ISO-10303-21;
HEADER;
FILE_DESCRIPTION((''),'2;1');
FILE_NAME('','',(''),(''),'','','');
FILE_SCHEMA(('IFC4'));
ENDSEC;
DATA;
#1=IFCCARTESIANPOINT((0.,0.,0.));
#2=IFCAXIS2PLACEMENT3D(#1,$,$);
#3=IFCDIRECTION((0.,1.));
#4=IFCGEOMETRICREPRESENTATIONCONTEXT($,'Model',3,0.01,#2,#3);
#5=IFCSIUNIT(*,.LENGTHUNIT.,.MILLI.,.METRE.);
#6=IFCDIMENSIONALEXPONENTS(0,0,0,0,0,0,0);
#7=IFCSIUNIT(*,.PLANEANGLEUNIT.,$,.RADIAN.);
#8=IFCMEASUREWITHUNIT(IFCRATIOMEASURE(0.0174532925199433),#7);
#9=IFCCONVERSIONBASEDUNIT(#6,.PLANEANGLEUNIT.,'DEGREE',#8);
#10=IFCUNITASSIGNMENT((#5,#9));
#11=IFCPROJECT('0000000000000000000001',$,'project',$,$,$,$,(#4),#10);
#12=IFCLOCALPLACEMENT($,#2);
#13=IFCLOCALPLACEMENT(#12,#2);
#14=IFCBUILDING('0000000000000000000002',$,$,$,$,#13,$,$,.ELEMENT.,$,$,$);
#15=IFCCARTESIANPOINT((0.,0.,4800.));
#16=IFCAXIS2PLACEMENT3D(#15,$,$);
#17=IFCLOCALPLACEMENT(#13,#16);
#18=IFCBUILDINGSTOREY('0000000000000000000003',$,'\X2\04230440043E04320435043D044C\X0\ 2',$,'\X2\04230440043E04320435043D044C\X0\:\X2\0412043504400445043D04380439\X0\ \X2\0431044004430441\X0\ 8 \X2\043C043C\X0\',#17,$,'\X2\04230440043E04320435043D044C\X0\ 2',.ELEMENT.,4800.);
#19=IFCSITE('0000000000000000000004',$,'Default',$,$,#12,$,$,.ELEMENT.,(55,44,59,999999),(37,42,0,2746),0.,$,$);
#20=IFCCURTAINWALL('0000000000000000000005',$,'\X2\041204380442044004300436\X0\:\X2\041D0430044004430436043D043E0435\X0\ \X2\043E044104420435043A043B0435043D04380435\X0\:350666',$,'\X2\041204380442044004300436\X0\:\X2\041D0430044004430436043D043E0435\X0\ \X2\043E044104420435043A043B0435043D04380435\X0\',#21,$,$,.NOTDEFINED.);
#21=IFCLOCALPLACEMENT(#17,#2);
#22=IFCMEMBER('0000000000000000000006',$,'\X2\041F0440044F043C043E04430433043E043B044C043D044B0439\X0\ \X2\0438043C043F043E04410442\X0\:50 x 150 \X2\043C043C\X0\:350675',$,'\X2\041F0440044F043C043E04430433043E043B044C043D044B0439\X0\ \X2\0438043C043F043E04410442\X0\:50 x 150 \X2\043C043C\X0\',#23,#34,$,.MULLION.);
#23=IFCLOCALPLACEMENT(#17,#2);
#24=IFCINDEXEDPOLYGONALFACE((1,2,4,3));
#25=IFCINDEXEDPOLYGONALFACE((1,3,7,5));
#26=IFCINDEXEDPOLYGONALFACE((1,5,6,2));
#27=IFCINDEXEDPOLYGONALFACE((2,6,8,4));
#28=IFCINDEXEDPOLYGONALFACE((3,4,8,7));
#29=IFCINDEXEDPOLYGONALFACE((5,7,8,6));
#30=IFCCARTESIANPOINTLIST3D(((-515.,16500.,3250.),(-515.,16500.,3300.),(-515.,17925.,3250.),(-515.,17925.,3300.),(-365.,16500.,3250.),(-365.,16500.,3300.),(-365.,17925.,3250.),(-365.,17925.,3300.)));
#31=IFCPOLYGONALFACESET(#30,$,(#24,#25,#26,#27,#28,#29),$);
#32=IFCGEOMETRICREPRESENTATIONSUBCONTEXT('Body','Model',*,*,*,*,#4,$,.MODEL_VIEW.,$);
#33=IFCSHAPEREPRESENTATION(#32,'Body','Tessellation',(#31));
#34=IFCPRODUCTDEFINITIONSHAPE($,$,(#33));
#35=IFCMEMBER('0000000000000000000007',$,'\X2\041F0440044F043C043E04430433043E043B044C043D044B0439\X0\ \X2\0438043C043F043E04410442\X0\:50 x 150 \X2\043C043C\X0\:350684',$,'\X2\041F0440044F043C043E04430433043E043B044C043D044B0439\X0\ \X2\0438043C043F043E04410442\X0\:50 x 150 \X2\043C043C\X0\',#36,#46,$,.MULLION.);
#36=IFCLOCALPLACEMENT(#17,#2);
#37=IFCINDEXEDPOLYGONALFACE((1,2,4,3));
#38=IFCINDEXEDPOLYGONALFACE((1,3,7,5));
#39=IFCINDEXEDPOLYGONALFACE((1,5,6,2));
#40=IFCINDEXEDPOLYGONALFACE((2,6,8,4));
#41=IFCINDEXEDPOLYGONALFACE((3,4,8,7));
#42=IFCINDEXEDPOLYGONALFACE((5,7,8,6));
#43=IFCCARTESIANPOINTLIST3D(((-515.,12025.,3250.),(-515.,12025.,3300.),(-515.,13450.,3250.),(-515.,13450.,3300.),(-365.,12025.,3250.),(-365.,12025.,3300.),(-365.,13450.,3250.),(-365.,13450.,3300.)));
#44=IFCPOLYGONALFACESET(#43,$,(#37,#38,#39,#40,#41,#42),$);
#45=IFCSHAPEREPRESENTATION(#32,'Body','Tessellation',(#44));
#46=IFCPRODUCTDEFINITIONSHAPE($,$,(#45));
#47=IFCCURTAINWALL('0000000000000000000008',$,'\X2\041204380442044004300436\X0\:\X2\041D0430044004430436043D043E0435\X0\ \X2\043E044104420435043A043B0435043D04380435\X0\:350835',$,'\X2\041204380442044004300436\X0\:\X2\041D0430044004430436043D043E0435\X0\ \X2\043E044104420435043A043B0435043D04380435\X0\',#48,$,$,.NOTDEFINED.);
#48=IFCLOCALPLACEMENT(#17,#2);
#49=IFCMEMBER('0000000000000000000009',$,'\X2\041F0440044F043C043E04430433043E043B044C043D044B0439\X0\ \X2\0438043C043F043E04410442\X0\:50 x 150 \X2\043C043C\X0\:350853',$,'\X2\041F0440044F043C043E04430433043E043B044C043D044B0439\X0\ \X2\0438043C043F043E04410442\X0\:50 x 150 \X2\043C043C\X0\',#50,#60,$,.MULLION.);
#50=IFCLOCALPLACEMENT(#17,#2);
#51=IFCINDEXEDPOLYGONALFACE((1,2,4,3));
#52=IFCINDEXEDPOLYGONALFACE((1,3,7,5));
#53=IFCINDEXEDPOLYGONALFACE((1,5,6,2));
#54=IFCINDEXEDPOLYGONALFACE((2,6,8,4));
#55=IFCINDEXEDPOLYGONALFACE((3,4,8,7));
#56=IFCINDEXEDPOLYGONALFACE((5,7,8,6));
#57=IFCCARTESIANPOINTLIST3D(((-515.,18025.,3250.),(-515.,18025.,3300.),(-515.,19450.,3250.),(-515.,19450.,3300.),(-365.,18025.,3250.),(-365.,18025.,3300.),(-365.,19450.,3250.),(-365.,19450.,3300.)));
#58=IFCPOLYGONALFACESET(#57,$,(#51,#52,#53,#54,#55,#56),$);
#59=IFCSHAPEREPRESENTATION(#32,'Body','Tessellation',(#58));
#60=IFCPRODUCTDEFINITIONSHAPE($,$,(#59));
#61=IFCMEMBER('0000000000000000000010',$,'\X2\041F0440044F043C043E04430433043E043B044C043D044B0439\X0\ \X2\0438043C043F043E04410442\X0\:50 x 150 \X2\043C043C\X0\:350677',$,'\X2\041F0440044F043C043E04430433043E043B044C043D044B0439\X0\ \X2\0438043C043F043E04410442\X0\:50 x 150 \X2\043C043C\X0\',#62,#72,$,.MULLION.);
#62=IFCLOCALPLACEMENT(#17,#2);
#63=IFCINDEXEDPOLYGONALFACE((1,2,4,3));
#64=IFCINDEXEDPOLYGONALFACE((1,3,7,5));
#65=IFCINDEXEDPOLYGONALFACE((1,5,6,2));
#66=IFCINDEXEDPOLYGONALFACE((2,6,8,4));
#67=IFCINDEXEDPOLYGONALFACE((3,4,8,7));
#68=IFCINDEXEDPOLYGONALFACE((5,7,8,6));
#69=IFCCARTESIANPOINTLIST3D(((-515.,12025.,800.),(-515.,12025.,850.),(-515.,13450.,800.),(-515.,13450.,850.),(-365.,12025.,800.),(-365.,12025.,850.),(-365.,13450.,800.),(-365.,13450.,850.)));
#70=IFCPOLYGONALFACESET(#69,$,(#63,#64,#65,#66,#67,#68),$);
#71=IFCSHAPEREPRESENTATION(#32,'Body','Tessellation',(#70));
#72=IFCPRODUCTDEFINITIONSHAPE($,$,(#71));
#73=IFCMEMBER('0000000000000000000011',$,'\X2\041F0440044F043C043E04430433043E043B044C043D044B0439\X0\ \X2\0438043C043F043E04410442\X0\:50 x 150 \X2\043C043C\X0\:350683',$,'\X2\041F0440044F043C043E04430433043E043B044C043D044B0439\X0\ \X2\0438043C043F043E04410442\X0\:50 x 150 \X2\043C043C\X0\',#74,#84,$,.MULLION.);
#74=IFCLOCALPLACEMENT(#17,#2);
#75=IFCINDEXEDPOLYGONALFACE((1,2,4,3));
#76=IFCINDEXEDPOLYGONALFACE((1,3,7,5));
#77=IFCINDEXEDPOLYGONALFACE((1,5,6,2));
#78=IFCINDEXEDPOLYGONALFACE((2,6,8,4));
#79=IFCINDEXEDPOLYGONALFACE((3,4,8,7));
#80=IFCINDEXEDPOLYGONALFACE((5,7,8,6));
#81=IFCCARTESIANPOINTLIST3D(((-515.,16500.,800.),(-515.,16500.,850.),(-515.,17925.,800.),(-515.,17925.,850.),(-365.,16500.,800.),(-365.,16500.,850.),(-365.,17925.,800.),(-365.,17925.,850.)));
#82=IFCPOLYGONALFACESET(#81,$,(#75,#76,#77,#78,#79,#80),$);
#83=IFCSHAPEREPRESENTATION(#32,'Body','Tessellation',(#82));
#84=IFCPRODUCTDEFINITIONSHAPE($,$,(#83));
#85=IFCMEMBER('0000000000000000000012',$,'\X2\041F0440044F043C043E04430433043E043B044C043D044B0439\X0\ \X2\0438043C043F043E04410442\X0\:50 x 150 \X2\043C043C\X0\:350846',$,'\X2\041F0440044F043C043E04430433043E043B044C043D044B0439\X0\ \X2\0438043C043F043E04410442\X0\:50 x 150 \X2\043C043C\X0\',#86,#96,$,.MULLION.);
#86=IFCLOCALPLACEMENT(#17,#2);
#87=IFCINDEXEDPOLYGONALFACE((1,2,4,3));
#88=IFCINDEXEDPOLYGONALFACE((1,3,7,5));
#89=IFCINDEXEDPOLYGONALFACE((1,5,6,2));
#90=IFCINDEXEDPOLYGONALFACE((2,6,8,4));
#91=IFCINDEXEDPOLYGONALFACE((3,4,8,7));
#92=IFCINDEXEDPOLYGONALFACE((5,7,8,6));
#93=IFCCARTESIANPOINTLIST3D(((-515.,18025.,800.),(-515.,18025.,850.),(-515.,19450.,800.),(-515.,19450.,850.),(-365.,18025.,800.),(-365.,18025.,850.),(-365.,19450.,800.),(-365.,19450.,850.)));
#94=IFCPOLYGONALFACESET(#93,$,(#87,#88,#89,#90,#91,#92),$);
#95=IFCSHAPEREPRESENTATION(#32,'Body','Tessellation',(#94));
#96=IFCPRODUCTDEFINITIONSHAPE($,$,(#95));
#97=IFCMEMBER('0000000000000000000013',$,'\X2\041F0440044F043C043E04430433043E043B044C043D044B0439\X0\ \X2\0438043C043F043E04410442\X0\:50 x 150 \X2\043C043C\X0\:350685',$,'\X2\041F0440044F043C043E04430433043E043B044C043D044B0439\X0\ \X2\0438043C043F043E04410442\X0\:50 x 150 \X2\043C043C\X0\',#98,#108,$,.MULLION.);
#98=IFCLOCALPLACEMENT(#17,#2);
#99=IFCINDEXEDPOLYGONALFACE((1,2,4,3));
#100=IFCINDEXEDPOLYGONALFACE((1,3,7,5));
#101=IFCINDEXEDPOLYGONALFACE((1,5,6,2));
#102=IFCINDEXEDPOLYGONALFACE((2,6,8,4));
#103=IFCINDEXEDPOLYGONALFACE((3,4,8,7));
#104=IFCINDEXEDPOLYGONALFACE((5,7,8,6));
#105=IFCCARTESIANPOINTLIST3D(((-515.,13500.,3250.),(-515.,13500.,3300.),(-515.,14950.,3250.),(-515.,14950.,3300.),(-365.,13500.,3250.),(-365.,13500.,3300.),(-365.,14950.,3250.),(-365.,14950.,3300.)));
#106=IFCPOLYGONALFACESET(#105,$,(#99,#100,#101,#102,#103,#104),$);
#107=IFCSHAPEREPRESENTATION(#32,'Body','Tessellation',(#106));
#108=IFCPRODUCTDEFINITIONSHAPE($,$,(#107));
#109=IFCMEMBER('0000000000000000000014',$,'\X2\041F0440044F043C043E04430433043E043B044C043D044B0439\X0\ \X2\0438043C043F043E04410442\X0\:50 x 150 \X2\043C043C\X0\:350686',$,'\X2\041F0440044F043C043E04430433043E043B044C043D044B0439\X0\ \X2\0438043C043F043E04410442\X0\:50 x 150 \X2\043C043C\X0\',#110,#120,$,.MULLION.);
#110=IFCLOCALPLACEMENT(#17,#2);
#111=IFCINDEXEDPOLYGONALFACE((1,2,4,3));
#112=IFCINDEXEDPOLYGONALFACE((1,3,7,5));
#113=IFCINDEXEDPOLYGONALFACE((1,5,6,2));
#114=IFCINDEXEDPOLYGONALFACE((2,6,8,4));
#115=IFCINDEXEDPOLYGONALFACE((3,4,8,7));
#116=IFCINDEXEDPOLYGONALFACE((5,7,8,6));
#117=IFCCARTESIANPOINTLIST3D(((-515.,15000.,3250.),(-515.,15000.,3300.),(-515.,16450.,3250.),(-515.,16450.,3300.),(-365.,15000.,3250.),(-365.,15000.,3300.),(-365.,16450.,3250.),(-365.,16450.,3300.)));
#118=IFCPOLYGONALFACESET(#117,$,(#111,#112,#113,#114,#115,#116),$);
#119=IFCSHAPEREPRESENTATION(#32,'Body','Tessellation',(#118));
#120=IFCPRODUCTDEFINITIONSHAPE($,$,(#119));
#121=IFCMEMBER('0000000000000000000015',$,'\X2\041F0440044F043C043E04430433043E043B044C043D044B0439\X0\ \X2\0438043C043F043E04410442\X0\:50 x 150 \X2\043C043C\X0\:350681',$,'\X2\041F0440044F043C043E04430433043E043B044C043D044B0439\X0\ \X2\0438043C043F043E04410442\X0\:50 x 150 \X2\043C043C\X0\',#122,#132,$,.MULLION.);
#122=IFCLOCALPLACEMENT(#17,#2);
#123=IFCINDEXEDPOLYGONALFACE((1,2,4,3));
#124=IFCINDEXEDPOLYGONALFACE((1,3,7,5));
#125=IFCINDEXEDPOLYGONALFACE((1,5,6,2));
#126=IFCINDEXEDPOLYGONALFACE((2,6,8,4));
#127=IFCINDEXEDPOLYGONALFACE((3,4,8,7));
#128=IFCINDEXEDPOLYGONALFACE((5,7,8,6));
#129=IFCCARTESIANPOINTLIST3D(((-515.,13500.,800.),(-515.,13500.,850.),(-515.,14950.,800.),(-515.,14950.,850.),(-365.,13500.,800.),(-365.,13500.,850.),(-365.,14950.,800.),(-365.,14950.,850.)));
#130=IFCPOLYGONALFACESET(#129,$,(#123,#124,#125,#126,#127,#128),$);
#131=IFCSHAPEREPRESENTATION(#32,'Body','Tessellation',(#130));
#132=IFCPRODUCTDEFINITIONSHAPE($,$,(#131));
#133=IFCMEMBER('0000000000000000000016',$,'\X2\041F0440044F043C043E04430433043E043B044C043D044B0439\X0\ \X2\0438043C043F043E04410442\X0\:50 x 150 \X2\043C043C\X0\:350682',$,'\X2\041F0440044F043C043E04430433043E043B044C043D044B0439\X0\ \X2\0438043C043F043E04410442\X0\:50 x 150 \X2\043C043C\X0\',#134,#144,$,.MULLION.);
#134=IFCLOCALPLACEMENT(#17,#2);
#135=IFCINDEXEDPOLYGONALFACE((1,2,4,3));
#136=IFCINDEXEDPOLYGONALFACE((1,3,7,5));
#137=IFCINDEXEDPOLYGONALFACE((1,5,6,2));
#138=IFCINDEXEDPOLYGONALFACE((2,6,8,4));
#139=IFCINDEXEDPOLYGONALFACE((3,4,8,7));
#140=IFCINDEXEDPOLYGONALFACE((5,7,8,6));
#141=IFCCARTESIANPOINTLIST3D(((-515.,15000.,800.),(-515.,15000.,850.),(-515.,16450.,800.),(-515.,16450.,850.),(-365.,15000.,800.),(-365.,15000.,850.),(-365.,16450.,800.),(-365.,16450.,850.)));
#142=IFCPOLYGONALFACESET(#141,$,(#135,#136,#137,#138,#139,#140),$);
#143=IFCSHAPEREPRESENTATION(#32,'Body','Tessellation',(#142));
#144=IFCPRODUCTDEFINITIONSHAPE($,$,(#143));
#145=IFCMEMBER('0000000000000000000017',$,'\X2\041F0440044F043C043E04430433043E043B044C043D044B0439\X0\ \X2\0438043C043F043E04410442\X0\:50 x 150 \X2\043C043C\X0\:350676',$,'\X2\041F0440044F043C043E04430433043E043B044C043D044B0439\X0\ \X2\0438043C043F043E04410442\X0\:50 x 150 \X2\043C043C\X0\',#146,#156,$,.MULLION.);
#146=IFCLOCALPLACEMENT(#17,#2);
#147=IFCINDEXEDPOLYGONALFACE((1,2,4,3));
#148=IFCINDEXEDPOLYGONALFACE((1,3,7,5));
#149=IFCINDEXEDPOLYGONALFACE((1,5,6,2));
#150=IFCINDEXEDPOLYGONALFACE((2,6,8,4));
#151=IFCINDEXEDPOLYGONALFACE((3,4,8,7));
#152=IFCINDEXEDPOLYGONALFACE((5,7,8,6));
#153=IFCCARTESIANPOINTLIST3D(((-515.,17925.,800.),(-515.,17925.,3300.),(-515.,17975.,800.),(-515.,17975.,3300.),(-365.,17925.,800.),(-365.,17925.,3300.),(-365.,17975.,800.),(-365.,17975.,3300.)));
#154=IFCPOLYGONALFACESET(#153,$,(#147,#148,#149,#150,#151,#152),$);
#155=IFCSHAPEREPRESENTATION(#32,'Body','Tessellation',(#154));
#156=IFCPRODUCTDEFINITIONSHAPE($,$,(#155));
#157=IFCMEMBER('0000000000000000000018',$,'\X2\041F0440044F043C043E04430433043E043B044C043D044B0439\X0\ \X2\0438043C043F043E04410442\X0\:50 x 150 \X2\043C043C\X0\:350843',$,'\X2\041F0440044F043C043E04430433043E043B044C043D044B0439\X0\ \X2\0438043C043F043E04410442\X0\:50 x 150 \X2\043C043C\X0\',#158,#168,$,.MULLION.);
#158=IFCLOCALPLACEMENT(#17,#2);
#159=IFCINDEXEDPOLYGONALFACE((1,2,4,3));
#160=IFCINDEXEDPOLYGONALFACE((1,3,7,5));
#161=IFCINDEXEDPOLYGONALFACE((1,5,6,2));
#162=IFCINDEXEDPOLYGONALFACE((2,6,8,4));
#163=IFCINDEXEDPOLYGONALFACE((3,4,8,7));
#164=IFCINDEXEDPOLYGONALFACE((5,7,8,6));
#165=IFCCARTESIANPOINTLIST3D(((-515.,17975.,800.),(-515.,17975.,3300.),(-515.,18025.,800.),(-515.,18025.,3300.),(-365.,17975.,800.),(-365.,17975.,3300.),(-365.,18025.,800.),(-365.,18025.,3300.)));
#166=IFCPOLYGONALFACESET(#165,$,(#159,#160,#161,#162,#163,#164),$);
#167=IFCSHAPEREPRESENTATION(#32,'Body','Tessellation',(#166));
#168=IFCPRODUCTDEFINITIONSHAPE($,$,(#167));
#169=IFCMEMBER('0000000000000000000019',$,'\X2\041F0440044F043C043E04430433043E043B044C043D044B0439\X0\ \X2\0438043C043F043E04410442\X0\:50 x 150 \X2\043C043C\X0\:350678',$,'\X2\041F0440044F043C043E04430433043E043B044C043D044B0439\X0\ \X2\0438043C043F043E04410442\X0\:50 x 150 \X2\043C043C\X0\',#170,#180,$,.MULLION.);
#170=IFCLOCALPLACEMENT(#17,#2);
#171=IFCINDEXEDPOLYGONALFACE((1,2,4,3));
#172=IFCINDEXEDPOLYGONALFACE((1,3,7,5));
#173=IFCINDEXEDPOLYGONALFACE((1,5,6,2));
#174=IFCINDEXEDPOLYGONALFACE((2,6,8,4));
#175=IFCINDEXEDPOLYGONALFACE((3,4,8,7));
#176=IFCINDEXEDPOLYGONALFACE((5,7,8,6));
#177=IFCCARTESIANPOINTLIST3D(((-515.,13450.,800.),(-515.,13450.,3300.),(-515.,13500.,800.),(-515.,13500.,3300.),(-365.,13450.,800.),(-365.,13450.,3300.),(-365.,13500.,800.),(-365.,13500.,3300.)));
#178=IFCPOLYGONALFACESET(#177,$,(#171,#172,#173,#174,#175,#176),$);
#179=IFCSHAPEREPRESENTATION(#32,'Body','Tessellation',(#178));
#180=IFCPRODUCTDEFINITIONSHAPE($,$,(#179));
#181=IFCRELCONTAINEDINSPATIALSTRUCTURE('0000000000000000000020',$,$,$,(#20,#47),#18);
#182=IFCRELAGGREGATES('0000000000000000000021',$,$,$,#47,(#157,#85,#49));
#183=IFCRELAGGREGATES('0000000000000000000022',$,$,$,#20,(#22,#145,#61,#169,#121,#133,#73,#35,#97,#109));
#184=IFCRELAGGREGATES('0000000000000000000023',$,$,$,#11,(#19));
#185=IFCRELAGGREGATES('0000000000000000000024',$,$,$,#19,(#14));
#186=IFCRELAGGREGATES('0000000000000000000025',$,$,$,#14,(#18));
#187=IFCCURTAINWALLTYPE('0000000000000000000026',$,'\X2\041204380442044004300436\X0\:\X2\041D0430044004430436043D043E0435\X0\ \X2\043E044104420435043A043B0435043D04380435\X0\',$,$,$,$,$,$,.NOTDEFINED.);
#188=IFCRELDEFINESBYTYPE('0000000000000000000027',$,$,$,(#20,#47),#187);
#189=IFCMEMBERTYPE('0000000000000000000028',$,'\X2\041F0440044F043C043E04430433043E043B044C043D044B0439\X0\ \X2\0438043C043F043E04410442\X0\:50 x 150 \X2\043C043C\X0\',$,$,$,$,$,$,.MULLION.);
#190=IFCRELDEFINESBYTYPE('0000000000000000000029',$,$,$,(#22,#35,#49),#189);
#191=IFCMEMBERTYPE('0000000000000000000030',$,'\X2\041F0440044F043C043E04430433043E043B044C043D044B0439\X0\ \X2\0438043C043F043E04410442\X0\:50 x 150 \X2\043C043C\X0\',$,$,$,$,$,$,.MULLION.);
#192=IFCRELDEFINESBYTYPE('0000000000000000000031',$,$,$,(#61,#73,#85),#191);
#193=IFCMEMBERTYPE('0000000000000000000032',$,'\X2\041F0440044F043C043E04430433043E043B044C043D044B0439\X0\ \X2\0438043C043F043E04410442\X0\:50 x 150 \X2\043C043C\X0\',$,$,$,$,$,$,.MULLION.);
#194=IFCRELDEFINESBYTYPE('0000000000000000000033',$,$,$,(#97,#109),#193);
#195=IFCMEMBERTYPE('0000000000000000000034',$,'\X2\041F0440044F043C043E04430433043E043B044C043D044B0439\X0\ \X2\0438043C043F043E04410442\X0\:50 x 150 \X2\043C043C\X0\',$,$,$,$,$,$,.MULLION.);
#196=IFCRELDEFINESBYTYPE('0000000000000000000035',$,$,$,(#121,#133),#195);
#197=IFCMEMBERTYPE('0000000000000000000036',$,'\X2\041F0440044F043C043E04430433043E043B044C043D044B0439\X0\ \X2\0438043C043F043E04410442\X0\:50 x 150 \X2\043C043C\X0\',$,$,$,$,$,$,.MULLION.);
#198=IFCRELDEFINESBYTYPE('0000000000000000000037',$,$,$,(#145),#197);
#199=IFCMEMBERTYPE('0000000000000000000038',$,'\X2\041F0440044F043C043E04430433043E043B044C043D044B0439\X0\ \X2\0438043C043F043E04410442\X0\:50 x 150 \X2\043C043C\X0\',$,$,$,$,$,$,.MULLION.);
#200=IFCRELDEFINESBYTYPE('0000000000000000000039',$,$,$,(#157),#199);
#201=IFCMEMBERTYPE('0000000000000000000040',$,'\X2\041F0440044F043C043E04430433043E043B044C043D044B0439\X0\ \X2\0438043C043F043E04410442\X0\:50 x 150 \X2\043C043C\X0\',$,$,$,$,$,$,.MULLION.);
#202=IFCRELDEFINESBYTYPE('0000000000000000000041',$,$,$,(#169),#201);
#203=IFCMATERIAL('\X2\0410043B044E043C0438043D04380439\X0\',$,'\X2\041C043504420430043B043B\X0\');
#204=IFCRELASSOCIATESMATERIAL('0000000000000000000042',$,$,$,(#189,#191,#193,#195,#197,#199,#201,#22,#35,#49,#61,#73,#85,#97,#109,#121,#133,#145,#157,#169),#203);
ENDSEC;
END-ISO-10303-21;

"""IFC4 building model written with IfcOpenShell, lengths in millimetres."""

from ifc_helpers import new_model, entity, si_unit, converted_unit, direction, frame, origin, origin_2d_with_axis, place, context, subcontext, project, spatial, rectangle, extrude, source, transform, mapped, material, material_profile, profile_set, profile_usage, type_object, type_shapes, element, aggregate, save


model = new_model("IFC4")

# Units and contexts
model_context = context("Model", 3, precision=0.01, world=origin(), true_north=direction((0.0, 1.0)))
body_context = subcontext(model_context, "Body", "Model", "MODEL_VIEW")
ifc_project = project(units=[si_unit("LENGTHUNIT", "METRE", prefix="MILLI"), converted_unit("PLANEANGLEUNIT", "DEGREE", entity("IfcRatioMeasure", 0.0174532925199433), si_unit("PLANEANGLEUNIT", "RADIAN"), dimensions=[0, 0, 0, 0, 0, 0, 0])], contexts=[model_context])

# Site, building, storey
site_placement = place(None, origin())
site = spatial("IfcSite", under=ifc_project, at=site_placement, Name="Default", CompositionType="ELEMENT", RefLatitude=(55, 44, 59, 999999), RefLongitude=(37, 42, 0, 2746), RefElevation=0.0)
building_placement = place(site_placement, origin())
building = spatial("IfcBuilding", under=site, at=building_placement, CompositionType="ELEMENT")
storey_placement = place(building_placement, frame((0.0, 0.0, 4800.0)))
storey = spatial("IfcBuildingStorey", under=building, at=storey_placement, Name="Уровень 2", ObjectType="Уровень:Верхний брус 8 мм", LongName="Уровень 2", CompositionType="ELEMENT", Elevation=4800.0)

# Curtain wall, members
curtain_wall_type = type_object("IfcCurtainWallType", Name="Витраж:Наружное остекление", PredefinedType="NOTDEFINED")
curtain_wall_1_placement = place(storey_placement, frame((0.0, 0.0, -4800.0)))
curtain_wall_1 = element("IfcCurtainWall", 1, at=curtain_wall_1_placement, inside=storey, type_object=curtain_wall_type, Name="Витраж:Наружное остекление:350666", ObjectType="Витраж:Наружное остекление", PredefinedType="NOTDEFINED")
ifc_material_1 = material(Name="Алюминий", Category="Металл")
ifc_material_profile = material_profile(ifc_material_1, rectangle(XDim=150.0, YDim=50.0, at=origin_2d_with_axis()), Name="50 x 150 мм")
ifc_profile_set = profile_set([ifc_material_profile], Name="50 x 150 мм")
ifc_profile_usage_1 = profile_usage(ifc_profile_set)
member_type_1 = type_object("IfcMemberType", Name="Прямоугольный импост:50 x 150 мм", PredefinedType="MULLION", material=ifc_profile_set)
shared_shape_1 = source(origin(), body_context, "Body", "SweptSolid", [
    extrude(rectangle(XDim=150.0, YDim=50.0, at=origin_2d_with_axis()), frame((-25.0, 0.0, -1425.0), z_axis=(0.0, 0.0, 1.0), x_axis=(0.0, -1.0, 0.0)), (0.0, 0.0, 1.0), 1425.0),
])
type_shapes(member_type_1, [shared_shape_1])
member_1_placement = place(storey_placement, frame((-440.0, 17925.0, 3300.0), z_axis=(0.0, 1.0, 0.0), x_axis=(0.0, 0.0, 1.0)))
member_1 = element("IfcMember", 2, at=member_1_placement, type_object=member_type_1, material=ifc_profile_usage_1, Name="Прямоугольный импост:50 x 150 мм:350675", ObjectType="Прямоугольный импост:50 x 150 мм", PredefinedType="MULLION", context=body_context, shape_type="MappedRepresentation", body=[
    mapped(shared_shape_1, transform((0.0, 0.0, 0.0), scale=1.0)),
])
ifc_profile_usage_2 = profile_usage(ifc_profile_set)
member_2_placement = place(storey_placement, frame((-440.0, 13450.0, 3300.0), z_axis=(0.0, 1.0, 0.0), x_axis=(0.0, 0.0, 1.0)))
member_2 = element("IfcMember", 3, at=member_2_placement, type_object=member_type_1, material=ifc_profile_usage_2, Name="Прямоугольный импост:50 x 150 мм:350684", ObjectType="Прямоугольный импост:50 x 150 мм", PredefinedType="MULLION", context=body_context, shape_type="MappedRepresentation", body=[
    mapped(shared_shape_1, transform((0.0, 0.0, 0.0), scale=1.0)),
])

# Curtain wall, member
curtain_wall_2_placement = place(storey_placement, frame((0.0, 0.0, -4800.0)))
curtain_wall_2 = element("IfcCurtainWall", 4, at=curtain_wall_2_placement, inside=storey, type_object=curtain_wall_type, Name="Витраж:Наружное остекление:350835", ObjectType="Витраж:Наружное остекление", PredefinedType="NOTDEFINED")
ifc_profile_usage_3 = profile_usage(ifc_profile_set)
member_3_placement = place(storey_placement, frame((-440.0, 19450.0, 3300.0), z_axis=(0.0, 1.0, 0.0), x_axis=(0.0, 0.0, 1.0)))
member_3 = element("IfcMember", 5, at=member_3_placement, type_object=member_type_1, material=ifc_profile_usage_3, Name="Прямоугольный импост:50 x 150 мм:350853", ObjectType="Прямоугольный импост:50 x 150 мм", PredefinedType="MULLION", context=body_context, shape_type="MappedRepresentation", body=[
    mapped(shared_shape_1, transform((0.0, 0.0, 0.0), scale=1.0)),
])

# Members
ifc_profile_usage_4 = profile_usage(ifc_profile_set)
member_type_2 = type_object("IfcMemberType", Name="Прямоугольный импост:50 x 150 мм", PredefinedType="MULLION", material=ifc_profile_set)
shared_shape_2 = source(origin(), body_context, "Body", "SweptSolid", [
    extrude(rectangle(XDim=150.0, YDim=50.0, at=origin_2d_with_axis()), frame((-25.0, 0.0, -1425.0), z_axis=(0.0, 0.0, 1.0), x_axis=(0.0, -1.0, 0.0)), (0.0, 0.0, 1.0), 1425.0),
])
type_shapes(member_type_2, [shared_shape_2])
member_4_placement = place(storey_placement, frame((-440.0, 12025.0, 800.0), z_axis=(0.0, -1.0, 0.0), x_axis=(0.0, 0.0, -1.0)))
member_4 = element("IfcMember", 6, at=member_4_placement, type_object=member_type_2, material=ifc_profile_usage_4, Name="Прямоугольный импост:50 x 150 мм:350677", ObjectType="Прямоугольный импост:50 x 150 мм", PredefinedType="MULLION", context=body_context, shape_type="MappedRepresentation", body=[
    mapped(shared_shape_2, transform((0.0, 0.0, 0.0), scale=1.0)),
])
ifc_profile_usage_5 = profile_usage(ifc_profile_set)
member_5_placement = place(storey_placement, frame((-440.0, 16500.0, 800.0), z_axis=(0.0, -1.0, 0.0), x_axis=(0.0, 0.0, -1.0)))
member_5 = element("IfcMember", 7, at=member_5_placement, type_object=member_type_2, material=ifc_profile_usage_5, Name="Прямоугольный импост:50 x 150 мм:350683", ObjectType="Прямоугольный импост:50 x 150 мм", PredefinedType="MULLION", context=body_context, shape_type="MappedRepresentation", body=[
    mapped(shared_shape_2, transform((0.0, 0.0, 0.0), scale=1.0)),
])
ifc_profile_usage_6 = profile_usage(ifc_profile_set)
member_6_placement = place(storey_placement, frame((-440.0, 18025.0, 800.0), z_axis=(0.0, -1.0, 0.0), x_axis=(0.0, 0.0, -1.0)))
member_6 = element("IfcMember", 8, at=member_6_placement, type_object=member_type_2, material=ifc_profile_usage_6, Name="Прямоугольный импост:50 x 150 мм:350846", ObjectType="Прямоугольный импост:50 x 150 мм", PredefinedType="MULLION", context=body_context, shape_type="MappedRepresentation", body=[
    mapped(shared_shape_2, transform((0.0, 0.0, 0.0), scale=1.0)),
])
ifc_profile_usage_7 = profile_usage(ifc_profile_set)
member_type_3 = type_object("IfcMemberType", Name="Прямоугольный импост:50 x 150 мм", PredefinedType="MULLION", material=ifc_profile_set)
shared_shape_3 = source(origin(), body_context, "Body", "SweptSolid", [
    extrude(rectangle(XDim=150.0, YDim=50.0, at=origin_2d_with_axis()), frame((-25.0, 0.0, -1450.0), z_axis=(0.0, 0.0, 1.0), x_axis=(0.0, -1.0, 0.0)), (0.0, 0.0, 1.0), 1450.0),
])
type_shapes(member_type_3, [shared_shape_3])
member_7_placement = place(storey_placement, frame((-440.0, 14950.0, 3300.0), z_axis=(0.0, 1.0, 0.0), x_axis=(0.0, 0.0, 1.0)))
member_7 = element("IfcMember", 9, at=member_7_placement, type_object=member_type_3, material=ifc_profile_usage_7, Name="Прямоугольный импост:50 x 150 мм:350685", ObjectType="Прямоугольный импост:50 x 150 мм", PredefinedType="MULLION", context=body_context, shape_type="MappedRepresentation", body=[
    mapped(shared_shape_3, transform((0.0, 0.0, 0.0), scale=1.0)),
])
ifc_profile_usage_8 = profile_usage(ifc_profile_set)
member_8_placement = place(storey_placement, frame((-440.0, 16450.0, 3300.0), z_axis=(0.0, 1.0, 0.0), x_axis=(0.0, 0.0, 1.0)))
member_8 = element("IfcMember", 10, at=member_8_placement, type_object=member_type_3, material=ifc_profile_usage_8, Name="Прямоугольный импост:50 x 150 мм:350686", ObjectType="Прямоугольный импост:50 x 150 мм", PredefinedType="MULLION", context=body_context, shape_type="MappedRepresentation", body=[
    mapped(shared_shape_3, transform((0.0, 0.0, 0.0), scale=1.0)),
])
ifc_profile_usage_9 = profile_usage(ifc_profile_set)
member_type_4 = type_object("IfcMemberType", Name="Прямоугольный импост:50 x 150 мм", PredefinedType="MULLION", material=ifc_profile_set)
shared_shape_4 = source(origin(), body_context, "Body", "SweptSolid", [
    extrude(rectangle(XDim=150.0, YDim=50.0, at=origin_2d_with_axis()), frame((-25.0, 0.0, -1450.0), z_axis=(0.0, 0.0, 1.0), x_axis=(0.0, -1.0, 0.0)), (0.0, 0.0, 1.0), 1450.0),
])
type_shapes(member_type_4, [shared_shape_4])
member_9_placement = place(storey_placement, frame((-440.0, 13500.0, 800.0), z_axis=(0.0, -1.0, 0.0), x_axis=(0.0, 0.0, -1.0)))
member_9 = element("IfcMember", 11, at=member_9_placement, type_object=member_type_4, material=ifc_profile_usage_9, Name="Прямоугольный импост:50 x 150 мм:350681", ObjectType="Прямоугольный импост:50 x 150 мм", PredefinedType="MULLION", context=body_context, shape_type="MappedRepresentation", body=[
    mapped(shared_shape_4, transform((0.0, 0.0, 0.0), scale=1.0)),
])
ifc_profile_usage_10 = profile_usage(ifc_profile_set)
member_10_placement = place(storey_placement, frame((-440.0, 15000.0, 800.0), z_axis=(0.0, -1.0, 0.0), x_axis=(0.0, 0.0, -1.0)))
member_10 = element("IfcMember", 12, at=member_10_placement, type_object=member_type_4, material=ifc_profile_usage_10, Name="Прямоугольный импост:50 x 150 мм:350682", ObjectType="Прямоугольный импост:50 x 150 мм", PredefinedType="MULLION", context=body_context, shape_type="MappedRepresentation", body=[
    mapped(shared_shape_4, transform((0.0, 0.0, 0.0), scale=1.0)),
])
ifc_profile_usage_11 = profile_usage(ifc_profile_set)
member_type_5 = type_object("IfcMemberType", Name="Прямоугольный импост:50 x 150 мм", PredefinedType="MULLION", material=ifc_profile_set)
shared_shape_5 = source(origin(), body_context, "Body", "SweptSolid", [
    extrude(rectangle(XDim=150.0, YDim=50.0, at=origin_2d_with_axis()), frame((-25.0, 0.0, -2500.0), z_axis=(0.0, 0.0, 1.0), x_axis=(0.0, -1.0, 0.0)), (0.0, 0.0, 1.0), 2500.0),
])
type_shapes(member_type_5, [shared_shape_5])
member_11_placement = place(storey_placement, frame((-440.0, 17975.0, 800.0), z_axis=(0.0, 0.0, -1.0), x_axis=(0.0, 1.0, 0.0)))
member_11 = element("IfcMember", 13, at=member_11_placement, type_object=member_type_5, material=ifc_profile_usage_11, Name="Прямоугольный импост:50 x 150 мм:350676", ObjectType="Прямоугольный импост:50 x 150 мм", PredefinedType="MULLION", context=body_context, shape_type="MappedRepresentation", body=[
    mapped(shared_shape_5, transform((0.0, 0.0, 0.0), scale=1.0)),
])
ifc_profile_usage_12 = profile_usage(ifc_profile_set)
member_type_6 = type_object("IfcMemberType", Name="Прямоугольный импост:50 x 150 мм", PredefinedType="MULLION", material=ifc_profile_set)
shared_shape_6 = source(origin(), body_context, "Body", "SweptSolid", [
    extrude(rectangle(XDim=150.0, YDim=50.0, at=origin_2d_with_axis()), frame((-25.0, 0.0, -2500.0), z_axis=(0.0, 0.0, 1.0), x_axis=(0.0, -1.0, 0.0)), (0.0, 0.0, 1.0), 2500.0),
])
type_shapes(member_type_6, [shared_shape_6])
member_12_placement = place(storey_placement, frame((-440.0, 17975.0, 3300.0), z_axis=(0.0, 0.0, 1.0), x_axis=(0.0, -1.0, 0.0)))
member_12 = element("IfcMember", 14, at=member_12_placement, type_object=member_type_6, material=ifc_profile_usage_12, Name="Прямоугольный импост:50 x 150 мм:350843", ObjectType="Прямоугольный импост:50 x 150 мм", PredefinedType="MULLION", context=body_context, shape_type="MappedRepresentation", body=[
    mapped(shared_shape_6, transform((0.0, 0.0, 0.0), scale=1.0)),
])
ifc_profile_usage_13 = profile_usage(ifc_profile_set)
member_type_7 = type_object("IfcMemberType", Name="Прямоугольный импост:50 x 150 мм", PredefinedType="MULLION", material=ifc_profile_set)
shared_shape_7 = source(origin(), body_context, "Body", "SweptSolid", [
    extrude(rectangle(XDim=150.0, YDim=50.0, at=origin_2d_with_axis()), frame((0.0, 0.0, -2500.0), z_axis=(0.0, 0.0, 1.0), x_axis=(0.0, -1.0, 0.0)), (0.0, 0.0, 1.0), 2500.0),
])
type_shapes(member_type_7, [shared_shape_7])
member_13_placement = place(storey_placement, frame((-440.0, 13475.0, 800.0), z_axis=(0.0, 0.0, -1.0), x_axis=(0.0, 1.0, 0.0)))
member_13 = element("IfcMember", 15, at=member_13_placement, type_object=member_type_7, material=ifc_profile_usage_13, Name="Прямоугольный импост:50 x 150 мм:350678", ObjectType="Прямоугольный импост:50 x 150 мм", PredefinedType="MULLION", context=body_context, shape_type="MappedRepresentation", body=[
    mapped(shared_shape_7, transform((0.0, 0.0, 0.0), scale=1.0)),
])

aggregate(curtain_wall_2, [member_12, member_6, member_3])
aggregate(curtain_wall_1, [member_1, member_11, member_4, member_13, member_9, member_10, member_5, member_2, member_7, member_8])

save(model, "model.ifc")
